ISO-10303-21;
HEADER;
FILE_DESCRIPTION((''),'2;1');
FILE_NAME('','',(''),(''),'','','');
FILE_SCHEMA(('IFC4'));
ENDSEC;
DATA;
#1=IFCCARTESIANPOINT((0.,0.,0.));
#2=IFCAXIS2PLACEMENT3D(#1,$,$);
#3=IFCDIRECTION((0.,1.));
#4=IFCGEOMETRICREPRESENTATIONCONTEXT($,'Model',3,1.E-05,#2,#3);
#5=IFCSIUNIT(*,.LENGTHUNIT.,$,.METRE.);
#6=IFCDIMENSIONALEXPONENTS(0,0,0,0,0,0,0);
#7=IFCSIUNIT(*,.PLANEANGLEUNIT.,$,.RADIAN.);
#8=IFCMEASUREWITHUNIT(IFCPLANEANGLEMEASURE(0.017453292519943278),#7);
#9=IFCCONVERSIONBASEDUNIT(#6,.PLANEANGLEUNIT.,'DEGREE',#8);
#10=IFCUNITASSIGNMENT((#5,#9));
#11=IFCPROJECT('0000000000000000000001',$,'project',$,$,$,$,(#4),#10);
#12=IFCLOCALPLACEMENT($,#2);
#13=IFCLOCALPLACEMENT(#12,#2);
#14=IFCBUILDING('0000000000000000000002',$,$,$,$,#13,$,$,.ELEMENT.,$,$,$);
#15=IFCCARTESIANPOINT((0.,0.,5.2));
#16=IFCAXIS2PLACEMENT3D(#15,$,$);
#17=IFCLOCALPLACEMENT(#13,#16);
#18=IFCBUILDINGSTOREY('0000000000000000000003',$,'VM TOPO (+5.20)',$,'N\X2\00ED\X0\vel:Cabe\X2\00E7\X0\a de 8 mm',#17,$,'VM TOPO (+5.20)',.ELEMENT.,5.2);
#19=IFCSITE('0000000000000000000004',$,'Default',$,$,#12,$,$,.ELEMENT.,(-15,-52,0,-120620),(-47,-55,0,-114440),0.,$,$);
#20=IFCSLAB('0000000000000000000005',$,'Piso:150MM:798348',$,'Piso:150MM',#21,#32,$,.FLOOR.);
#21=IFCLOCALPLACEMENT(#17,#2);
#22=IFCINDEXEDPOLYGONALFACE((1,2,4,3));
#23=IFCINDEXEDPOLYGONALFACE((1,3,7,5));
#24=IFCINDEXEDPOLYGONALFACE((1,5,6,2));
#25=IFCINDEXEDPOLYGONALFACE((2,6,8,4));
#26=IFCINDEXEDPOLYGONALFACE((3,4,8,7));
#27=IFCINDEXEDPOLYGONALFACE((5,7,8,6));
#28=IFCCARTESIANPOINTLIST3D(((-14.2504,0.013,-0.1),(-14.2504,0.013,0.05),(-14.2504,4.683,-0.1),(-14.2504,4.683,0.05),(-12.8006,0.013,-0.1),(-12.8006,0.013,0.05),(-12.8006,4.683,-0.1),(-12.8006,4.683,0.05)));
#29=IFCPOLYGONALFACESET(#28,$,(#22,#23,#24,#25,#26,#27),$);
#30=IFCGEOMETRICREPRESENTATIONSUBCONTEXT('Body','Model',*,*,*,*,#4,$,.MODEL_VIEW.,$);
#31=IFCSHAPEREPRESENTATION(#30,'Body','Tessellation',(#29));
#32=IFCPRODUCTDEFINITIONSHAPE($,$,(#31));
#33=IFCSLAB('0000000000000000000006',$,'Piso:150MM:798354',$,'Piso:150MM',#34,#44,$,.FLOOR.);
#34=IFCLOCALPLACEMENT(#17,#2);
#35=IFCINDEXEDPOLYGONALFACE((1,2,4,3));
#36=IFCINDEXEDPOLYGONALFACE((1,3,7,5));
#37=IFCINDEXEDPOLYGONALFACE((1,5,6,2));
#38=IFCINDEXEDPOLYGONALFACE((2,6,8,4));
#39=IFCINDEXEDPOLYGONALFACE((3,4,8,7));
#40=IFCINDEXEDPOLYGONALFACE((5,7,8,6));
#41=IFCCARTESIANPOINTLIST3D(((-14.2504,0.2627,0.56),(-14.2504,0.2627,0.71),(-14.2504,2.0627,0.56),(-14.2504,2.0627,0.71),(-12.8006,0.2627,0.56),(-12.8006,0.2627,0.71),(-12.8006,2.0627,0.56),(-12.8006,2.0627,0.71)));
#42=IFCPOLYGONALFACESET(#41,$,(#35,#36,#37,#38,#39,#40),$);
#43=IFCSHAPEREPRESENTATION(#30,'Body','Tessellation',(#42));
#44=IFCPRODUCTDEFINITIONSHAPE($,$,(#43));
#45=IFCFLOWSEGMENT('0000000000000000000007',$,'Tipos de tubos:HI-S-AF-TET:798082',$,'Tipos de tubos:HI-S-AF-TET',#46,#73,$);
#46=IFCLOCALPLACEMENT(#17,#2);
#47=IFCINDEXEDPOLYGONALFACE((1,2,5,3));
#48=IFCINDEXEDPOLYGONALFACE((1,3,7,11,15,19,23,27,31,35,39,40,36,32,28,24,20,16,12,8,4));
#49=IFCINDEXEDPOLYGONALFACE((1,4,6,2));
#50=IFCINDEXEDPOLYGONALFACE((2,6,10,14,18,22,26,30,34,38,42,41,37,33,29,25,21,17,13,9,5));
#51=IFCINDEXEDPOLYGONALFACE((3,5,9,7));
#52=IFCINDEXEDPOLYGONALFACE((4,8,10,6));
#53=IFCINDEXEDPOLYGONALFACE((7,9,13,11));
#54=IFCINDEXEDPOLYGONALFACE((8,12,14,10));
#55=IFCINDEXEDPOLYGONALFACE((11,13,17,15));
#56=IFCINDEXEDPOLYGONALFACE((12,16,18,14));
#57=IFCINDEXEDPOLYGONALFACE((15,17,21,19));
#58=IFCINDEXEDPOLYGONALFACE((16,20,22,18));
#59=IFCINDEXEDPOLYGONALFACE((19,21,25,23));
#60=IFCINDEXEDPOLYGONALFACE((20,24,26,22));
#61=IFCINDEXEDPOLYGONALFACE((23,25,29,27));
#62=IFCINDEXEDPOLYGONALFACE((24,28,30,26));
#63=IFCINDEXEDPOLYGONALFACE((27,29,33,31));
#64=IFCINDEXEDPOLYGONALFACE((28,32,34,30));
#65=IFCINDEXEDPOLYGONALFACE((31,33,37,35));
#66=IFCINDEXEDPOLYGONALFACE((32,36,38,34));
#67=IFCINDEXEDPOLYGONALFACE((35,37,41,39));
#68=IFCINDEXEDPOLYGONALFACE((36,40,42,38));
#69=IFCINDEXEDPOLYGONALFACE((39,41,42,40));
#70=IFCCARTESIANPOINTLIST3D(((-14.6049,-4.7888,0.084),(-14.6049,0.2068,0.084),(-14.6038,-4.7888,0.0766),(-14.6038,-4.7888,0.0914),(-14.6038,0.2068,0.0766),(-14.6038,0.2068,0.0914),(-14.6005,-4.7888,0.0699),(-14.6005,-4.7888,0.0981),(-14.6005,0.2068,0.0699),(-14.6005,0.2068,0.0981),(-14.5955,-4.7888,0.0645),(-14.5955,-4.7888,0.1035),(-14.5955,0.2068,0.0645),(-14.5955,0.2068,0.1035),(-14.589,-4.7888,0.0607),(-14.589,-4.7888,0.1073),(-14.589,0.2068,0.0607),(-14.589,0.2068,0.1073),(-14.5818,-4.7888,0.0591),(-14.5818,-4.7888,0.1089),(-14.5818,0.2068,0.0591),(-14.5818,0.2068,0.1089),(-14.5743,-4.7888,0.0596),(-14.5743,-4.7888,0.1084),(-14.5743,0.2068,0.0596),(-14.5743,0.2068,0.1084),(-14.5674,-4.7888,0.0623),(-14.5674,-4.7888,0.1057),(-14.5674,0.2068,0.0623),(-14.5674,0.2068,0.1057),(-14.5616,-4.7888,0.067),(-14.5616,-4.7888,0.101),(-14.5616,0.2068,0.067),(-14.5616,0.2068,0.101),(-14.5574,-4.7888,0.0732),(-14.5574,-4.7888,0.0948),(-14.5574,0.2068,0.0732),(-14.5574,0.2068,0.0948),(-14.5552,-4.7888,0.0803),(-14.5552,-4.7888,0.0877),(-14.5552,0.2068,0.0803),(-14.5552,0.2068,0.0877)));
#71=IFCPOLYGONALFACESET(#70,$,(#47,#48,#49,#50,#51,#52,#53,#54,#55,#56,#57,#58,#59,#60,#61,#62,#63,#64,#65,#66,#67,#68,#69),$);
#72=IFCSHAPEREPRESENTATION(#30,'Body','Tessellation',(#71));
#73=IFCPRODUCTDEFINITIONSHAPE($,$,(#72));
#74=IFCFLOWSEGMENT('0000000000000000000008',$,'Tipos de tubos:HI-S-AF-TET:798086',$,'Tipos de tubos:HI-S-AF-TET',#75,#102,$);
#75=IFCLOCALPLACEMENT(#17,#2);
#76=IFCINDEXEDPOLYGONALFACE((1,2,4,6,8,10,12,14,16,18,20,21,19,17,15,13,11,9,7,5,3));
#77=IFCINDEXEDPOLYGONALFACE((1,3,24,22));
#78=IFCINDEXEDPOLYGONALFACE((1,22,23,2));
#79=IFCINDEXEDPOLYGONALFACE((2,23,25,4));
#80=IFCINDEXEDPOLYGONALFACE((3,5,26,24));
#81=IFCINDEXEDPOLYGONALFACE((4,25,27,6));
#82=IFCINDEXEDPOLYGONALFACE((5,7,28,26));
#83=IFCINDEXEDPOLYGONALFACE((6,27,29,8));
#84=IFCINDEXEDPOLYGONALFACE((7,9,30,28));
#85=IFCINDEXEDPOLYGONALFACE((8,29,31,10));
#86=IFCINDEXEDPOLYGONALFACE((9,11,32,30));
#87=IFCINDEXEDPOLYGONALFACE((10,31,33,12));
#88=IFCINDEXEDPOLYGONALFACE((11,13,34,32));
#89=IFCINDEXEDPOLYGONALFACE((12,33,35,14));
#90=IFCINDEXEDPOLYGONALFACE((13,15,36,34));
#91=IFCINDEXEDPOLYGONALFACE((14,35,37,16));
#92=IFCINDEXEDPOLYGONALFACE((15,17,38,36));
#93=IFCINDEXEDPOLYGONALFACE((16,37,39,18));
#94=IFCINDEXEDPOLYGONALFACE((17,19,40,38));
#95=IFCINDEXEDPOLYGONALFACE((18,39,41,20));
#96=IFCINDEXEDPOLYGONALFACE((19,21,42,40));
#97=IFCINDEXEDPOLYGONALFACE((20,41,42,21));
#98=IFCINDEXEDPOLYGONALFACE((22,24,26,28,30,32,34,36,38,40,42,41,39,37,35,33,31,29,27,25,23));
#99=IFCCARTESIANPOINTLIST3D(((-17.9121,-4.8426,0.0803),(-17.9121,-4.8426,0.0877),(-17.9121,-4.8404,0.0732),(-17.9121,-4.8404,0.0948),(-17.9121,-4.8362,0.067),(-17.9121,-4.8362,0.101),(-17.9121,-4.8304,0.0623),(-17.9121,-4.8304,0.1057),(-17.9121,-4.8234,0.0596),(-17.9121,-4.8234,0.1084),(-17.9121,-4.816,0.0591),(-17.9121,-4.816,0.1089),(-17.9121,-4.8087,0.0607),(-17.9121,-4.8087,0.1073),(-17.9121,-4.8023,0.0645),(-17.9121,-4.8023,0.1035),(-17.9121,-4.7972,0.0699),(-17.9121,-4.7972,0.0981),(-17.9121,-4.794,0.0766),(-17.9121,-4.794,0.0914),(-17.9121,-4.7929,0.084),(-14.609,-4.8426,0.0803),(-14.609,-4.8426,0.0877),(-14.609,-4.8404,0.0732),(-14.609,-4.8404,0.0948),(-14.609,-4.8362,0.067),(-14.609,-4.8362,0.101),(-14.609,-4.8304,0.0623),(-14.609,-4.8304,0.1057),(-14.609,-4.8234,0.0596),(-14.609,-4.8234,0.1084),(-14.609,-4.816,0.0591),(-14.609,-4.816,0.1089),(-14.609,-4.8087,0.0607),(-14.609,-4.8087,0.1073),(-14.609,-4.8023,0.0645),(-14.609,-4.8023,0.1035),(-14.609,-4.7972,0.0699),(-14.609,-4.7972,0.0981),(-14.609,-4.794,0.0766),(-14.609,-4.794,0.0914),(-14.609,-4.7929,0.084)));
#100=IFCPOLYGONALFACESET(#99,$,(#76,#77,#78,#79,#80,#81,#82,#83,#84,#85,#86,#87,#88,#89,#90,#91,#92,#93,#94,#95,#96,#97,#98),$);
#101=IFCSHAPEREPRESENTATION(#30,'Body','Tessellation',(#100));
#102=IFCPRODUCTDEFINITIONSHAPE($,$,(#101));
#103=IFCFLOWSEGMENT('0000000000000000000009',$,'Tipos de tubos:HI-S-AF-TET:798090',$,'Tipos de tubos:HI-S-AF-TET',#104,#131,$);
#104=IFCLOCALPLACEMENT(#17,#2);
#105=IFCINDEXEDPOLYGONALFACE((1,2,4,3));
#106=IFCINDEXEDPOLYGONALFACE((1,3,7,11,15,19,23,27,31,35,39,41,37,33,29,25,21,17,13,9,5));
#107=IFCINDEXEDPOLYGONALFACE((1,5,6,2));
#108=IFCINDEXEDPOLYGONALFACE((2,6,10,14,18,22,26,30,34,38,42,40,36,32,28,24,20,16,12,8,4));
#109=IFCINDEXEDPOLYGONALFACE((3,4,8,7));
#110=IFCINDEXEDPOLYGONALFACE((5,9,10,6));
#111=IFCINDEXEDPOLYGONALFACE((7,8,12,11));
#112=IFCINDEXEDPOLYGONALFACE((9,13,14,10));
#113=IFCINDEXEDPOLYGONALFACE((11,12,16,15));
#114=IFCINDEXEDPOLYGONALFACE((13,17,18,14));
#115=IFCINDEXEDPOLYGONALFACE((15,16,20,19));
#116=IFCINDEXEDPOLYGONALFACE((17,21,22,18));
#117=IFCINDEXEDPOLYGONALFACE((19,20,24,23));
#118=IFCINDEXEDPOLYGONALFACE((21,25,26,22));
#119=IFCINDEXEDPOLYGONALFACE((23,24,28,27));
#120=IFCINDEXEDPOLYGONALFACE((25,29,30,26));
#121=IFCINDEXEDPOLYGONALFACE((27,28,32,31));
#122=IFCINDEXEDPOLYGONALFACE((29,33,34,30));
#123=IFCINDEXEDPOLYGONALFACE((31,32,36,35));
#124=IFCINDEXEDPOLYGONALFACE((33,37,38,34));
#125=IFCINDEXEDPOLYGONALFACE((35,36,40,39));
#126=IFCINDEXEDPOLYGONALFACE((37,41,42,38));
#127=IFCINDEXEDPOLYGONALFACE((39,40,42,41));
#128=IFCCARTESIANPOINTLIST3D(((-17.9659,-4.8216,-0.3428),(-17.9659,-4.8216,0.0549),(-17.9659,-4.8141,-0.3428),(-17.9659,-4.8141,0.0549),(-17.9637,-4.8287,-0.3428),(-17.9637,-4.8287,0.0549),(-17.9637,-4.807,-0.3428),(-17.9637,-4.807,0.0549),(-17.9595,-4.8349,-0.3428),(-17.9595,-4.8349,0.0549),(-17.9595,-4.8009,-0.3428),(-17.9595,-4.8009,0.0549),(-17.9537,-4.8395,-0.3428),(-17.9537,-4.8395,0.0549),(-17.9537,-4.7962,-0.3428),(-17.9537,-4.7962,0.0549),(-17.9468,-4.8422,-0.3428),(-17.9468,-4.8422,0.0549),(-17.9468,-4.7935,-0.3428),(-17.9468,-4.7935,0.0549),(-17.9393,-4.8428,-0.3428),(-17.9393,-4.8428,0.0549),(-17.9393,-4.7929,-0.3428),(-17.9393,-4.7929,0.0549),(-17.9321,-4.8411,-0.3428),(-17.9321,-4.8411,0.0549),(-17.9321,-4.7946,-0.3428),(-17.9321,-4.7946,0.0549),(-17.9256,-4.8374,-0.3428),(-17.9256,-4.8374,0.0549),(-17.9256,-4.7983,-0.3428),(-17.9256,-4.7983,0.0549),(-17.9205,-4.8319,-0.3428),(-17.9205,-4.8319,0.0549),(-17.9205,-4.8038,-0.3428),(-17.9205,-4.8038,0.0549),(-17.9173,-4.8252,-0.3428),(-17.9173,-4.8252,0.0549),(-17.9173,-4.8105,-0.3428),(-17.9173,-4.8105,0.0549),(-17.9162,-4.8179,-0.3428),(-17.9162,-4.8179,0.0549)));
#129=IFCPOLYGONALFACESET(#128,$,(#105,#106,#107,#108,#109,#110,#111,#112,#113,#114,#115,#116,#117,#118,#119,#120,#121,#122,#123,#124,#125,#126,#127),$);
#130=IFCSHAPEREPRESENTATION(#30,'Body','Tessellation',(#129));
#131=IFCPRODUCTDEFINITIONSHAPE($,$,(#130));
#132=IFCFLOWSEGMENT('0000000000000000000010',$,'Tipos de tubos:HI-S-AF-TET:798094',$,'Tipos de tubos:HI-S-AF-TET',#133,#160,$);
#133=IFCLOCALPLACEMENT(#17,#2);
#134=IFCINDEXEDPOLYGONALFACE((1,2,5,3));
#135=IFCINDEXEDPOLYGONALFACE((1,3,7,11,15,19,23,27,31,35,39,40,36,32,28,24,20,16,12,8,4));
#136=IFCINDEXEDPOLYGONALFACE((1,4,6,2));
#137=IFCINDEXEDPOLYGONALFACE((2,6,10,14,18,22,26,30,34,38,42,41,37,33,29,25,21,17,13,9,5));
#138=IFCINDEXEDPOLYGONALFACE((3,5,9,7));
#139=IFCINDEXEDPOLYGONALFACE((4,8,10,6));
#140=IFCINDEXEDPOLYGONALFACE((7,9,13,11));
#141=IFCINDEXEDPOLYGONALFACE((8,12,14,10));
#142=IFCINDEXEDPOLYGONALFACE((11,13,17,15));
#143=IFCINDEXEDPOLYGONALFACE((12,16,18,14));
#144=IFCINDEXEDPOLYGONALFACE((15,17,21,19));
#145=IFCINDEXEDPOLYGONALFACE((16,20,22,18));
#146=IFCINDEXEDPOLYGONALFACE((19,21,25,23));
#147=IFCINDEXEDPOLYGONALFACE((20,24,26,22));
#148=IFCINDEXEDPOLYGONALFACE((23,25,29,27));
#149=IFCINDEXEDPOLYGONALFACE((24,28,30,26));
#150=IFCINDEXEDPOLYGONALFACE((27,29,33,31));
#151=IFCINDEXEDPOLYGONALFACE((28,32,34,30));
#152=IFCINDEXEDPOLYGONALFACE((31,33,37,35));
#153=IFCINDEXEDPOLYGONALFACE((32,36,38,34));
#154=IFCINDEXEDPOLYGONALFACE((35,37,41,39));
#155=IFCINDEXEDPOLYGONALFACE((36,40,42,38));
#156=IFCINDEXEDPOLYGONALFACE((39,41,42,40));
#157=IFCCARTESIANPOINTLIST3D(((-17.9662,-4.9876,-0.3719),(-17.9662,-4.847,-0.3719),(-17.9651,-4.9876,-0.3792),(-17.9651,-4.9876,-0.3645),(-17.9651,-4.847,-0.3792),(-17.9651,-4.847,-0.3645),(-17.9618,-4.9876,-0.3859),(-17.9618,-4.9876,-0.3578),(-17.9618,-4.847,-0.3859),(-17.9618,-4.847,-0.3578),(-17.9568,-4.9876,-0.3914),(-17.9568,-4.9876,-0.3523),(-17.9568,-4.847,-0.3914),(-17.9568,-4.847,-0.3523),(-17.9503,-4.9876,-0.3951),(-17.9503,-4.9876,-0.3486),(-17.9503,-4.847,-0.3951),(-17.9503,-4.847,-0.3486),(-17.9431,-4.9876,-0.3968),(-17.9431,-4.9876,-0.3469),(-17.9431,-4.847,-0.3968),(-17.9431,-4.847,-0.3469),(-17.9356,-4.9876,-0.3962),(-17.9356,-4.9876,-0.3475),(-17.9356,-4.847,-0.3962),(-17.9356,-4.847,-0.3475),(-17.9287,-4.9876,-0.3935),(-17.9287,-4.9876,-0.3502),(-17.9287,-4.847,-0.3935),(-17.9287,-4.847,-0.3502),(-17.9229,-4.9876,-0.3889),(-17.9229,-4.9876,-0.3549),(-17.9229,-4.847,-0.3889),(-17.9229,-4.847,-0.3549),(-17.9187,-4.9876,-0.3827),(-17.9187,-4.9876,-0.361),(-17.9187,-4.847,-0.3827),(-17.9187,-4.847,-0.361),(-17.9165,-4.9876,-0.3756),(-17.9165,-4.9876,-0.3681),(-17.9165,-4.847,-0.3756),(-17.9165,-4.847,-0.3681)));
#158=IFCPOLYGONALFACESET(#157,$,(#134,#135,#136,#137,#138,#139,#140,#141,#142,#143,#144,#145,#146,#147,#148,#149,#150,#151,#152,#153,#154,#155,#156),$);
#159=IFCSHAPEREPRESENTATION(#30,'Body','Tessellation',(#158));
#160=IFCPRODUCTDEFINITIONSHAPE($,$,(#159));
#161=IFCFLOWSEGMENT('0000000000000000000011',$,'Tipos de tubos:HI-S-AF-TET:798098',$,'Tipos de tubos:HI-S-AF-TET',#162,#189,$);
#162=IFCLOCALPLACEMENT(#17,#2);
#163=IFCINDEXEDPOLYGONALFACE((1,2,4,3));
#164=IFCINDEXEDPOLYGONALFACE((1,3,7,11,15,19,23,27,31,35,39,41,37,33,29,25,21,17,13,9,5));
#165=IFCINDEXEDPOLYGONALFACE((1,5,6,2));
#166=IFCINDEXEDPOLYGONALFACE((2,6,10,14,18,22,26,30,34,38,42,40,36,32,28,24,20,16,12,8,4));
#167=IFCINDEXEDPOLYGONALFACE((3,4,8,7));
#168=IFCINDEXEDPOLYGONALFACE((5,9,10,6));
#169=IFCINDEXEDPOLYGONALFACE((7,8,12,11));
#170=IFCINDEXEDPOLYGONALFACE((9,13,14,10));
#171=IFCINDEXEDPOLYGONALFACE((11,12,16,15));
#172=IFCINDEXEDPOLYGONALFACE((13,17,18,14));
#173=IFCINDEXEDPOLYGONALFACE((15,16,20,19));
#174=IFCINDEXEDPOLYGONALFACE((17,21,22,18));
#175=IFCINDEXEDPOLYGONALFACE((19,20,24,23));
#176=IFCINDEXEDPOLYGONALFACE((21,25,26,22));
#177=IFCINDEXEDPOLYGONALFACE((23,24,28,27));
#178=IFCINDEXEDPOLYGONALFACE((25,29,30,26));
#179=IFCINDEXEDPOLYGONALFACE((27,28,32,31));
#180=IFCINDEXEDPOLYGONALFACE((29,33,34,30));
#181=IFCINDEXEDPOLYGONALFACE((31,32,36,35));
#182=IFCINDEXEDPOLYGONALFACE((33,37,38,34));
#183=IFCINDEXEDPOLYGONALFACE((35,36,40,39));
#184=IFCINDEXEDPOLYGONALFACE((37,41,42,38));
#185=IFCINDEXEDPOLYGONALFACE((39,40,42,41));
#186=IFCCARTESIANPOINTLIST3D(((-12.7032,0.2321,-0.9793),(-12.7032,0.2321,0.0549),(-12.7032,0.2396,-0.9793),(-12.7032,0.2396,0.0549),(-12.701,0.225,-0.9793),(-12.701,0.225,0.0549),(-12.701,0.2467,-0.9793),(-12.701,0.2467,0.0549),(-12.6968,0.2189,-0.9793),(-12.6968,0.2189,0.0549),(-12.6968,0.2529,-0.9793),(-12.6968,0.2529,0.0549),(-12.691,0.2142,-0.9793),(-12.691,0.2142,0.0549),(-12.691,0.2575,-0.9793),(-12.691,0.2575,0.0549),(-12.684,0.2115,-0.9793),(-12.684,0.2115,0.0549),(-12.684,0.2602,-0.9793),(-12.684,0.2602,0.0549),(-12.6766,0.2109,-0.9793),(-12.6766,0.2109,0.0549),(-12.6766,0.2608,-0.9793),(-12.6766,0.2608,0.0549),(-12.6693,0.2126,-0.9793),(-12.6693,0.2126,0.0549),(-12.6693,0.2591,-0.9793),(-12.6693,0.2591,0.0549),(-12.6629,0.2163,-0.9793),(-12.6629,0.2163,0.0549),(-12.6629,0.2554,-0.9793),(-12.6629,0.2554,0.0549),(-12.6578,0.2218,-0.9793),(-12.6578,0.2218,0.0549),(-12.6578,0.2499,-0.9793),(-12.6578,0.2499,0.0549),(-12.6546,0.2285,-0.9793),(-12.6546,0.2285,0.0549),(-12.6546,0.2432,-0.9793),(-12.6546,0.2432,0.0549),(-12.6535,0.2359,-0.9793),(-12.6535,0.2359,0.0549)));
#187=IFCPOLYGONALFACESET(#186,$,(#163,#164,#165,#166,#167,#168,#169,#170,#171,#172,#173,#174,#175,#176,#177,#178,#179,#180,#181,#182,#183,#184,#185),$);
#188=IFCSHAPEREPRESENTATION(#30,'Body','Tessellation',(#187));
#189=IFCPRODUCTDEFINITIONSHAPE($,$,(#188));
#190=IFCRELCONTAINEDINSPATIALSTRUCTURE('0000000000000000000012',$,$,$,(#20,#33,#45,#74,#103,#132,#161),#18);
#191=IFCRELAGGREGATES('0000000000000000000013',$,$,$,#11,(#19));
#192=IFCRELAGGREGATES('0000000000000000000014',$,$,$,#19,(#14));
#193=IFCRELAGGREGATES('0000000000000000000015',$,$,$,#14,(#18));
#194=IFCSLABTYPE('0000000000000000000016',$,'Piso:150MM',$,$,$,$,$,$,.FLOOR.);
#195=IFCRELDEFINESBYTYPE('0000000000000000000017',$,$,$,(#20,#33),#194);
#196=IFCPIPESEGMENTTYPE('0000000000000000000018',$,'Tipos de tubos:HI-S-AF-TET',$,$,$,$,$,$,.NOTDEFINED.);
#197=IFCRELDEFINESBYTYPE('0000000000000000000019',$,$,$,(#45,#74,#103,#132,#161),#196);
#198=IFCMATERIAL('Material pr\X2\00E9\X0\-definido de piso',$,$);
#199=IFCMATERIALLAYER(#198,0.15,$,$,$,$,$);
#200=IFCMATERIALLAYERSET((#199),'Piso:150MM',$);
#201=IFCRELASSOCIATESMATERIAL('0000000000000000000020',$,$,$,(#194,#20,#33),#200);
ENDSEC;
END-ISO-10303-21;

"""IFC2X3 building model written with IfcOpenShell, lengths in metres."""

from ifc_helpers import new_model, entity, si_unit, converted_unit, direction, frame, frame_2d, origin, origin_2d_with_axis, place, context, subcontext, project, spatial, rectangle, circle, extrude, material, layer, layer_set, layer_usage, type_object, element, save


model = new_model("IFC2X3")

# Units and contexts
model_context = context("Model", 3, precision=1e-05, world=origin(), true_north=direction((0.0, 1.0)))
body_context = subcontext(model_context, "Body", "Model", "MODEL_VIEW")
ifc_project = project(units=[si_unit("LENGTHUNIT", "METRE"), converted_unit("PLANEANGLEUNIT", "DEGREE", entity("IfcPlaneAngleMeasure", 0.017453292519943278), si_unit("PLANEANGLEUNIT", "RADIAN"), dimensions=[0, 0, 0, 0, 0, 0, 0])], contexts=[model_context])

# Site, building, storey
site_placement = place(None, origin())
site = spatial("IfcSite", under=ifc_project, at=site_placement, Name="Default", CompositionType="ELEMENT", RefLatitude=(-15, -52, 0, -120620), RefLongitude=(-47, -55, 0, -114440), RefElevation=0.0)
building_placement = place(site_placement, origin())
building = spatial("IfcBuilding", under=site, at=building_placement, CompositionType="ELEMENT")
storey_placement = place(building_placement, frame((0.0, 0.0, 5.2)))
storey = spatial("IfcBuildingStorey", under=building, at=storey_placement, Name="VM TOPO (+5.20)", ObjectType="Nível:Cabeça de 8 mm", LongName="VM TOPO (+5.20)", CompositionType="ELEMENT", Elevation=5.2)

# Slabs
ifc_material_1 = material(Name="Material pré-definido de piso")
ifc_layer = layer(ifc_material_1, 0.15)
ifc_layer_set = layer_set([ifc_layer], Name="Piso:150MM")
ifc_layer_usage_1 = layer_usage(ifc_layer_set, "AXIS3", "POSITIVE", 0.0)
slab_type = type_object("IfcSlabType", Name="Piso:150MM", PredefinedType="FLOOR", material=ifc_layer_set)
slab_1_placement = place(storey_placement, origin())
element("IfcSlab", 1, at=slab_1_placement, inside=storey, type_object=slab_type, material=ifc_layer_usage_1, Name="Piso:150MM:798348", ObjectType="Piso:150MM", PredefinedType="FLOOR", context=body_context, shape_type="SweptSolid", body=[
    extrude(rectangle(XDim=4.67, YDim=1.4499, at=frame_2d((0.0, 0.0), x_axis=(1.0, 0.0))), frame((-13.5255, 2.348, 0.05), z_axis=(0.0, 0.0, -1.0), x_axis=(0.0, 1.0, 0.0)), (0.0, 0.0, 1.0), 0.15),
])
ifc_layer_usage_2 = layer_usage(ifc_layer_set, "AXIS3", "POSITIVE", 0.0)
slab_2_placement = place(storey_placement, origin())
element("IfcSlab", 2, at=slab_2_placement, inside=storey, type_object=slab_type, material=ifc_layer_usage_2, Name="Piso:150MM:798354", ObjectType="Piso:150MM", PredefinedType="FLOOR", context=body_context, shape_type="SweptSolid", body=[
    extrude(rectangle(XDim=1.8, YDim=1.4499, at=frame_2d((0.0, 0.0), x_axis=(1.0, 0.0))), frame((-13.5255, 1.1627, 0.71), z_axis=(0.0, 0.0, -1.0), x_axis=(0.0, 1.0, 0.0)), (0.0, 0.0, 1.0), 0.15),
])

# Flow segments
pipe_segment_type_1 = type_object("IfcPipeSegmentType", Name="Tipos de tubos:HI-S-AF-TET", PredefinedType="NOTDEFINED")
flow_segment_1_placement = place(storey_placement, origin())
element("IfcFlowSegment", 3, at=flow_segment_1_placement, inside=storey, type_object=pipe_segment_type_1, Name="Tipos de tubos:HI-S-AF-TET:798082", ObjectType="Tipos de tubos:HI-S-AF-TET", context=body_context, shape_type="SweptSolid", body=[
    extrude(circle(Radius=0.025, at=origin_2d_with_axis()), frame((-14.5799, -4.7888, 0.084), z_axis=(0.0, 1.0, 0.0), x_axis=(-1.0, 0.0, 0.0)), (0.0, 0.0, 1.0), 4.9955),
])
flow_segment_2_placement = place(storey_placement, origin())
element("IfcFlowSegment", 4, at=flow_segment_2_placement, inside=storey, type_object=pipe_segment_type_1, Name="Tipos de tubos:HI-S-AF-TET:798086", ObjectType="Tipos de tubos:HI-S-AF-TET", context=body_context, shape_type="SweptSolid", body=[
    extrude(circle(Radius=0.025, at=frame_2d((0.0, 0.0), x_axis=(1.0, 0.0))), frame((-17.9121, -4.8179, 0.084), z_axis=(1.0, 0.0, 0.0), x_axis=(0.0, 1.0, 0.0)), (0.0, 0.0, 1.0), 3.3031),
])
flow_segment_3_placement = place(storey_placement, origin())
element("IfcFlowSegment", 5, at=flow_segment_3_placement, inside=storey, type_object=pipe_segment_type_1, Name="Tipos de tubos:HI-S-AF-TET:798090", ObjectType="Tipos de tubos:HI-S-AF-TET", context=body_context, shape_type="SweptSolid", body=[
    extrude(circle(Radius=0.025, at=frame_2d((0.0, 0.0), x_axis=(1.0, 0.0))), frame((-17.9412, -4.8179, -0.3428)), (0.0, 0.0, 1.0), 0.3977),
])
flow_segment_4_placement = place(storey_placement, origin())
element("IfcFlowSegment", 6, at=flow_segment_4_placement, inside=storey, type_object=pipe_segment_type_1, Name="Tipos de tubos:HI-S-AF-TET:798094", ObjectType="Tipos de tubos:HI-S-AF-TET", context=body_context, shape_type="SweptSolid", body=[
    extrude(circle(Radius=0.025, at=origin_2d_with_axis()), frame((-17.9412, -4.9876, -0.3719), z_axis=(0.0, 1.0, 0.0), x_axis=(-1.0, 0.0, 0.0)), (0.0, 0.0, 1.0), 0.1407),
])
flow_segment_5_placement = place(storey_placement, origin())
element("IfcFlowSegment", 7, at=flow_segment_5_placement, inside=storey, type_object=pipe_segment_type_1, Name="Tipos de tubos:HI-S-AF-TET:798098", ObjectType="Tipos de tubos:HI-S-AF-TET", context=body_context, shape_type="SweptSolid", body=[
    extrude(circle(Radius=0.025, at=origin_2d_with_axis()), frame((-12.6785, 0.2359, -0.9793)), (0.0, 0.0, 1.0), 1.0342),
])

save(model, "model.ifc")
